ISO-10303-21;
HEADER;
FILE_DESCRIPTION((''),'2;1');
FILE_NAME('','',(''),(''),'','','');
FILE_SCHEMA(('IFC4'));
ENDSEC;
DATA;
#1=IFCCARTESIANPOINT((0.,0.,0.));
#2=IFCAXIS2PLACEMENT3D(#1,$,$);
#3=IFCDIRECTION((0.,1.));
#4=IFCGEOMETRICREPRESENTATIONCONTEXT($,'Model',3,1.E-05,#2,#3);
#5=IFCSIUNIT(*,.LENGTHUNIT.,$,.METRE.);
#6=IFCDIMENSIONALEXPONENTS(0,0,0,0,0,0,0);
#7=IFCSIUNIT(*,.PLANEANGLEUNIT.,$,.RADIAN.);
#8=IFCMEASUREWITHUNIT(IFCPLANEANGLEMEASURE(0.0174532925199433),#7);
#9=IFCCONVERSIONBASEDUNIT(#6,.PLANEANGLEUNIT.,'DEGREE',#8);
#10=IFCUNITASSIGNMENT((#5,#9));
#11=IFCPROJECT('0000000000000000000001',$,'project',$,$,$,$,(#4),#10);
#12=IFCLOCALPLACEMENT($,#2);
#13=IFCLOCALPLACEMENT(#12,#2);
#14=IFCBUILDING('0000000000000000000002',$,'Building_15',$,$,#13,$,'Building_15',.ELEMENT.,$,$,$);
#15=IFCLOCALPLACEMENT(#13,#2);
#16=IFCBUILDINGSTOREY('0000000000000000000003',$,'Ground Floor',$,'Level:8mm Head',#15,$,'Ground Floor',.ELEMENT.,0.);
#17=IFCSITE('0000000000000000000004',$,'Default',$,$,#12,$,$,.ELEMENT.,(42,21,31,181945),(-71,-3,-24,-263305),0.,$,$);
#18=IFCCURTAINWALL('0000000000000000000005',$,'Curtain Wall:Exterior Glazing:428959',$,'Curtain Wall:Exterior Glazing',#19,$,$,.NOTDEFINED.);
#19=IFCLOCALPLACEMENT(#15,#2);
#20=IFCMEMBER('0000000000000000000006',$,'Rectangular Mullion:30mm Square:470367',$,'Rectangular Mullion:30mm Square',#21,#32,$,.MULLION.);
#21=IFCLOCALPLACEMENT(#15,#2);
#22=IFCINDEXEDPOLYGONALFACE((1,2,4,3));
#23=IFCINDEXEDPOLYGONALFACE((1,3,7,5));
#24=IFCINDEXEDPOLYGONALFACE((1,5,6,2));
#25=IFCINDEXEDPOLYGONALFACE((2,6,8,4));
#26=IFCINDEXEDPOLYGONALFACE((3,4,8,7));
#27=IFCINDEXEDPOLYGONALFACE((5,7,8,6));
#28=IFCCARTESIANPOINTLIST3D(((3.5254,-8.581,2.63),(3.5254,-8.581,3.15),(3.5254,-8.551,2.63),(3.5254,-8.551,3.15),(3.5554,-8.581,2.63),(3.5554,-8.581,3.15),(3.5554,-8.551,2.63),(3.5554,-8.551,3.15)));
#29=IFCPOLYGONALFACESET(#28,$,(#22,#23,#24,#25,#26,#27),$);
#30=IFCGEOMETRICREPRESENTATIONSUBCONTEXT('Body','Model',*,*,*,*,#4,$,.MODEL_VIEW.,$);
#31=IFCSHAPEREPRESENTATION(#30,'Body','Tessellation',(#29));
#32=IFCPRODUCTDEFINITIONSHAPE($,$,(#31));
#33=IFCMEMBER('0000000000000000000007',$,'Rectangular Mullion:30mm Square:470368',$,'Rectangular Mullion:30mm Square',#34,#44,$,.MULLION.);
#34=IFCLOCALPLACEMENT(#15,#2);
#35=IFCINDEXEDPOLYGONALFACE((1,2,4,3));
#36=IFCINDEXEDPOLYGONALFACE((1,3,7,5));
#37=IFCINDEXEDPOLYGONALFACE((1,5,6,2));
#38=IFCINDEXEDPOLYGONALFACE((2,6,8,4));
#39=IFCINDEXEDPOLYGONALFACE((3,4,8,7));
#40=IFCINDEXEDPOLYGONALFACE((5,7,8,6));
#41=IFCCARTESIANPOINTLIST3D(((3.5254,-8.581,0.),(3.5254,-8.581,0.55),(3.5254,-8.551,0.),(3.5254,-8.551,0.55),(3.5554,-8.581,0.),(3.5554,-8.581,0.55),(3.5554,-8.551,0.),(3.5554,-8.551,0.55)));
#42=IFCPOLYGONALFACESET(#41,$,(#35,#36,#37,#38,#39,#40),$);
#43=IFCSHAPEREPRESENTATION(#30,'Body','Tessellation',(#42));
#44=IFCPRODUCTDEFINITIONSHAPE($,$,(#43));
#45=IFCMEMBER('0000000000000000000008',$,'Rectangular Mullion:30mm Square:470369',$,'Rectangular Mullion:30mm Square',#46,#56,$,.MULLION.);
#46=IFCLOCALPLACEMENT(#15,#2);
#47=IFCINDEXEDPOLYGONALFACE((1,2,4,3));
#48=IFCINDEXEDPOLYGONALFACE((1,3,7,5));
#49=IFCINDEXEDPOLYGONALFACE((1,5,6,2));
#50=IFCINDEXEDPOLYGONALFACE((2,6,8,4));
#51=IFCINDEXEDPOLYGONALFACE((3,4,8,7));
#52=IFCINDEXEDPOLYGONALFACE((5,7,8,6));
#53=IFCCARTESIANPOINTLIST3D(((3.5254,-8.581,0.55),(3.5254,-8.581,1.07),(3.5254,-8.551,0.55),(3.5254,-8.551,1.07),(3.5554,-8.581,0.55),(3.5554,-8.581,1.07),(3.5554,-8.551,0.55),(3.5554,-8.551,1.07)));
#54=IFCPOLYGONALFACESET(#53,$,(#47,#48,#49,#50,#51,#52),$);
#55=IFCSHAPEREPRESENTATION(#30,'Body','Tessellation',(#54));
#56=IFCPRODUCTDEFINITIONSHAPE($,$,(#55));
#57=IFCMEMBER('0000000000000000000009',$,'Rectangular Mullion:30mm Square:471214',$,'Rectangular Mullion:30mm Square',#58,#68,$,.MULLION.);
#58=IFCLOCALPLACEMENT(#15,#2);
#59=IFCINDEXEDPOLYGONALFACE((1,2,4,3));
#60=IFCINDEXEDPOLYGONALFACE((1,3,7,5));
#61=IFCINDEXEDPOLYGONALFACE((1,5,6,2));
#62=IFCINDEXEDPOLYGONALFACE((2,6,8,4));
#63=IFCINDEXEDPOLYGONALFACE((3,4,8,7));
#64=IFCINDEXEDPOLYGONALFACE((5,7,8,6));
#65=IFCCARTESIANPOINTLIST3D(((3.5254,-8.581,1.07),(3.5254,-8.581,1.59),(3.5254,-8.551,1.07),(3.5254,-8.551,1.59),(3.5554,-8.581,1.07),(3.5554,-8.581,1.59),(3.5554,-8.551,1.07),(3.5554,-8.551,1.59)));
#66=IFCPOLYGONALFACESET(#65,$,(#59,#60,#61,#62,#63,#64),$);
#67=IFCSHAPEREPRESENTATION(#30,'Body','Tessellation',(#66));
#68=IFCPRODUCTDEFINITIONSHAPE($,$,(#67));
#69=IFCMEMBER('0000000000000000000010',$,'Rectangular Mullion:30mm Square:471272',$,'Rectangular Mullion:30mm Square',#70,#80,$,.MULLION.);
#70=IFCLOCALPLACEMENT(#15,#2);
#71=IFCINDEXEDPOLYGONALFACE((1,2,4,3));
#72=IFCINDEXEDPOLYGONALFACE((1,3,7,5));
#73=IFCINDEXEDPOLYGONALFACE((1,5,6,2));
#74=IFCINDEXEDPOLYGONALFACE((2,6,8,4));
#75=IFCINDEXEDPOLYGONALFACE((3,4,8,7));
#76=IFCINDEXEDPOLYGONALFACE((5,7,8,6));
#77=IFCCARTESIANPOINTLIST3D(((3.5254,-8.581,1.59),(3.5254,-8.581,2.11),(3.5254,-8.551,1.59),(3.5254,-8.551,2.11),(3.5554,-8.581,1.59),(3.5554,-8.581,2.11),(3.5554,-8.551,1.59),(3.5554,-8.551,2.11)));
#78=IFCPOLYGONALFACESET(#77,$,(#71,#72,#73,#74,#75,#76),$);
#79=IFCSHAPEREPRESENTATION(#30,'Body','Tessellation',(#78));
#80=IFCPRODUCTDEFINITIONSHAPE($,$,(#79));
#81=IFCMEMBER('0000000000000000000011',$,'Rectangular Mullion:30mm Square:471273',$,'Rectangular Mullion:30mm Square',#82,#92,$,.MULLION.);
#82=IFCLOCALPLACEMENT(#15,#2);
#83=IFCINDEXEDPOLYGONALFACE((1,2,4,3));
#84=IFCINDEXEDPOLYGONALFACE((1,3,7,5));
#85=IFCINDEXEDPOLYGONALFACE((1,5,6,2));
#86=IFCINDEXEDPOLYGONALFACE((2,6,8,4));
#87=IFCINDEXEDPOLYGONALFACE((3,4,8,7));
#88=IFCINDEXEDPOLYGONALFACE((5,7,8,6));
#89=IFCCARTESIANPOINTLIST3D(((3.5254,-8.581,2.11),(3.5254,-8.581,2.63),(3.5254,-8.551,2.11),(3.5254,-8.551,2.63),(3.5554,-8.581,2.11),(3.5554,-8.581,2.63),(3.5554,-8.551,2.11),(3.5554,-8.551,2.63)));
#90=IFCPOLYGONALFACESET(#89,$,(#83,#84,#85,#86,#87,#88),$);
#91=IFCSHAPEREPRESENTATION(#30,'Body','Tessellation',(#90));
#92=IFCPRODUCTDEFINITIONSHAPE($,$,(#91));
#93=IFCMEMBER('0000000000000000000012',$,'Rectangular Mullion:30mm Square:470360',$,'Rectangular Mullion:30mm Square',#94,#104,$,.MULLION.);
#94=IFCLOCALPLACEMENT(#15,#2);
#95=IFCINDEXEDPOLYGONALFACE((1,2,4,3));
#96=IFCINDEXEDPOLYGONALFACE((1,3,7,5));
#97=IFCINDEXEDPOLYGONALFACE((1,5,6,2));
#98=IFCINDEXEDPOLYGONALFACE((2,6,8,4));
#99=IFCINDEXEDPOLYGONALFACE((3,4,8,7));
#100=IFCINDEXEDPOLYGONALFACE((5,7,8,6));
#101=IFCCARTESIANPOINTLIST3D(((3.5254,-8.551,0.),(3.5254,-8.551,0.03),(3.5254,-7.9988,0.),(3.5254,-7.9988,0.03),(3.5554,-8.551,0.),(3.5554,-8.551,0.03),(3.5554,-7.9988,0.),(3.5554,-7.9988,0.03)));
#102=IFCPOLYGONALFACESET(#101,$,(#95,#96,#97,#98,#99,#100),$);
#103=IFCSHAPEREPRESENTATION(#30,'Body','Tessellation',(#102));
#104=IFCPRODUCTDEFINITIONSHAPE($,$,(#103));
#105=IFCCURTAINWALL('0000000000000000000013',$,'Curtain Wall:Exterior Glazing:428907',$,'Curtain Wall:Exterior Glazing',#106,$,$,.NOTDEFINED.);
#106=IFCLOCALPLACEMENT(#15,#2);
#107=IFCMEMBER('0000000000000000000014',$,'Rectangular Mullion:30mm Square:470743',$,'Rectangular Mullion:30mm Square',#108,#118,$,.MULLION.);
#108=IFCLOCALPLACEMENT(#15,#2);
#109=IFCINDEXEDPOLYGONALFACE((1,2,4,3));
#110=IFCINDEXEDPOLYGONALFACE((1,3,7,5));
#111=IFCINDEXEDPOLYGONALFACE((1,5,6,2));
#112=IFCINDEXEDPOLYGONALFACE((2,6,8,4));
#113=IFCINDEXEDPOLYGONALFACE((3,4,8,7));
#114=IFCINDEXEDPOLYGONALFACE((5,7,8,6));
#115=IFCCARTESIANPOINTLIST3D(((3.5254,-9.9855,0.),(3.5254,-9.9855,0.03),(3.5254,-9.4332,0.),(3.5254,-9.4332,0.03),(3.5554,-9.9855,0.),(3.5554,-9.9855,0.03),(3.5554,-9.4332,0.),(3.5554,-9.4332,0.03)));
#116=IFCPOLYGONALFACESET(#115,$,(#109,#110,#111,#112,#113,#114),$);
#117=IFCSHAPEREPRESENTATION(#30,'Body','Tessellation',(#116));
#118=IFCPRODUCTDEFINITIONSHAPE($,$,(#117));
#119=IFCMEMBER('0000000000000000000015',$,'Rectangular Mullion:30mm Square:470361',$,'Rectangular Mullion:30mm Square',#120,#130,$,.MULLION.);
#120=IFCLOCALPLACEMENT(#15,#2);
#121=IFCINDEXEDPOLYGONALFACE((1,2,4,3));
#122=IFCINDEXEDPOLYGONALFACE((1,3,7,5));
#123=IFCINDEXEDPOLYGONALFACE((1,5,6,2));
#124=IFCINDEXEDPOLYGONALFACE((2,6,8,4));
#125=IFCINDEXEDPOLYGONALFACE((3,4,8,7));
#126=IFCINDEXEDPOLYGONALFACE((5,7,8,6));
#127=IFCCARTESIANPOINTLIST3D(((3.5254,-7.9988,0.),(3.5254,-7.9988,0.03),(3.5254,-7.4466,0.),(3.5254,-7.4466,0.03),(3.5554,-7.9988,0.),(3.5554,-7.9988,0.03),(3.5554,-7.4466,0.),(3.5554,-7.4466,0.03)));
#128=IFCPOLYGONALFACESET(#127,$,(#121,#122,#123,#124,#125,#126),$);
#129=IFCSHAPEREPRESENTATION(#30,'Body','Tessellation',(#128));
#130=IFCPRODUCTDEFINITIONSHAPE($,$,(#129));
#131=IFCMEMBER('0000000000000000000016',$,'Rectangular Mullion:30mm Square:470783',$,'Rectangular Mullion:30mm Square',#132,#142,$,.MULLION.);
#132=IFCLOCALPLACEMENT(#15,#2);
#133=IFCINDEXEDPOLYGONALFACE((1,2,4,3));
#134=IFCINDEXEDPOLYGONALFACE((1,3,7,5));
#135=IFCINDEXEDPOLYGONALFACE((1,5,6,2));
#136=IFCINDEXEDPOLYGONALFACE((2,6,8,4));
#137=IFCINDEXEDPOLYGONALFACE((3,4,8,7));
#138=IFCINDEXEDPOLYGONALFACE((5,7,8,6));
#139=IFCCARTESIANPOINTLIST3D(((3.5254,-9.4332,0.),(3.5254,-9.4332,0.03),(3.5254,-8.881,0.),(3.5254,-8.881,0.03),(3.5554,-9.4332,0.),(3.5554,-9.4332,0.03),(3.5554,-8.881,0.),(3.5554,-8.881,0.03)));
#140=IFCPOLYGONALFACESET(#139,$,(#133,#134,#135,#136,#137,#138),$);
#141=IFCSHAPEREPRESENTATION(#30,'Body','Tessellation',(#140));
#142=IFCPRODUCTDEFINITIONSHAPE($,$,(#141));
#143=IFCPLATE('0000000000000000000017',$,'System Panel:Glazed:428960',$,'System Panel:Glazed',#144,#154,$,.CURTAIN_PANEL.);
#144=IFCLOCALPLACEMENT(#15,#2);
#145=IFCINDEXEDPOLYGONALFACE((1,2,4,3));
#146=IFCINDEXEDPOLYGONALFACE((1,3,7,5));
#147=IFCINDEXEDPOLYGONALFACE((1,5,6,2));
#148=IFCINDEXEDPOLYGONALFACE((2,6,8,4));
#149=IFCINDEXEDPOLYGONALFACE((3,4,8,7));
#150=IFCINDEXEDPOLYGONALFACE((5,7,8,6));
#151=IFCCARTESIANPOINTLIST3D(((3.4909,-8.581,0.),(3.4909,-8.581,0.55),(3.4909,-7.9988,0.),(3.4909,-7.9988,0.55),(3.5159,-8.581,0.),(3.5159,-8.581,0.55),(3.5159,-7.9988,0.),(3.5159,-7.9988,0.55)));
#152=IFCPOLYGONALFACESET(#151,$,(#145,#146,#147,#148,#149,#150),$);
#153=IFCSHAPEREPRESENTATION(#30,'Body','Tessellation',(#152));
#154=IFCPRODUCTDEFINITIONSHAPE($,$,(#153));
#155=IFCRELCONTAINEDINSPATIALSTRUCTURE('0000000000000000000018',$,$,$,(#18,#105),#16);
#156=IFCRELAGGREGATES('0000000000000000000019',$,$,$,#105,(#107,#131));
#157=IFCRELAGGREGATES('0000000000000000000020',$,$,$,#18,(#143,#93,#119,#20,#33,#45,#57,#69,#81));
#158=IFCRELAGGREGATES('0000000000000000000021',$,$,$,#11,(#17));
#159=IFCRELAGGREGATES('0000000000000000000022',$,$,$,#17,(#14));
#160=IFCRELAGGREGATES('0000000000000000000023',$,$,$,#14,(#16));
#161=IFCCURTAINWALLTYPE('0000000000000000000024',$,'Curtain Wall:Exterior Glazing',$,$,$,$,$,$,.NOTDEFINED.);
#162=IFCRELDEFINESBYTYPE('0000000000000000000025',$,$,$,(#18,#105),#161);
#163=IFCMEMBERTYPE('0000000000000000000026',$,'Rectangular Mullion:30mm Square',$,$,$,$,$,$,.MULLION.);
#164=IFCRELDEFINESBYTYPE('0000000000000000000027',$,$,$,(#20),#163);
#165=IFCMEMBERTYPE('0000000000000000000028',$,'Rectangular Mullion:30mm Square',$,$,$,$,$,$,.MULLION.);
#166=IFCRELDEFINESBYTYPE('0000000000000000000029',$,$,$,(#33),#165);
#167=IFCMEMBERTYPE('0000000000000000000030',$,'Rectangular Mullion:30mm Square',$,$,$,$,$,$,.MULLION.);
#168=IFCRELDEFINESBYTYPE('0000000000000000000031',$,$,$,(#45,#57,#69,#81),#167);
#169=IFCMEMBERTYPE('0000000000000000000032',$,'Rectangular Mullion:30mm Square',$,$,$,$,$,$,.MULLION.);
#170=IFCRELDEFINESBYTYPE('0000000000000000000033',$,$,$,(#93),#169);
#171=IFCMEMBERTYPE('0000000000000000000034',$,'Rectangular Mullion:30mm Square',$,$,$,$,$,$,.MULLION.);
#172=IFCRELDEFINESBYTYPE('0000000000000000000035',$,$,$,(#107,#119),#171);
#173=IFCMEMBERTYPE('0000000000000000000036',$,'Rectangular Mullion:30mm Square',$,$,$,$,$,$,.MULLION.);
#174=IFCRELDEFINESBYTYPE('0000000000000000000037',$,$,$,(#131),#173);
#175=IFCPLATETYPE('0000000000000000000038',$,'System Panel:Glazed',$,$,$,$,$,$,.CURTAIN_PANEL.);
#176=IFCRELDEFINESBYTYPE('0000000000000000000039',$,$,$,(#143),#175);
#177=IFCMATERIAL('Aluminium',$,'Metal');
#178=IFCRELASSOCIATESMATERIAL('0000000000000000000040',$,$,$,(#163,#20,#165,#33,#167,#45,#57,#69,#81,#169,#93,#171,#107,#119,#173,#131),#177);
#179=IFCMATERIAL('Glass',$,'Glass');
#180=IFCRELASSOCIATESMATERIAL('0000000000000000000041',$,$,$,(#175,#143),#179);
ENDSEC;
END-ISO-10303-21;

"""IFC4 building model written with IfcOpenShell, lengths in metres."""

from ifc_helpers import new_model, entity, si_unit, converted_unit, direction, frame, origin, place, context, subcontext, project, spatial, indexed_curve, outline, extrude, source, transform, mapped, material, type_object, type_shapes, element, aggregate, save


model = new_model("IFC4")

# Units and contexts
model_context = context("Model", 3, precision=1e-05, world=origin(), true_north=direction((0.0, 1.0)))
body_context = subcontext(model_context, "Body", "Model", "MODEL_VIEW")
ifc_project = project(units=[si_unit("LENGTHUNIT", "METRE"), converted_unit("PLANEANGLEUNIT", "DEGREE", entity("IfcPlaneAngleMeasure", 0.0174532925199433), si_unit("PLANEANGLEUNIT", "RADIAN"), dimensions=[0, 0, 0, 0, 0, 0, 0])], contexts=[model_context])

# Site, building, storey
site_placement = place(None, origin())
site = spatial("IfcSite", under=ifc_project, at=site_placement, Name="Default", CompositionType="ELEMENT", RefLatitude=(42, 21, 31, 181945), RefLongitude=(-71, -3, -24, -263305), RefElevation=0.0)
building_placement = place(site_placement, origin())
building = spatial("IfcBuilding", under=site, at=building_placement, Name="Building_15", LongName="Building_15", CompositionType="ELEMENT")
storey_placement = place(building_placement, origin())
storey = spatial("IfcBuildingStorey", under=building, at=storey_placement, Name="Ground Floor", ObjectType="Level:8mm Head", LongName="Ground Floor", CompositionType="ELEMENT", Elevation=0.0)

# Curtain wall, members
curtain_wall_type = type_object("IfcCurtainWallType", Name="Curtain Wall:Exterior Glazing", PredefinedType="NOTDEFINED")
curtain_wall_1_placement = place(storey_placement, origin())
curtain_wall_1 = element("IfcCurtainWall", 1, at=curtain_wall_1_placement, inside=storey, type_object=curtain_wall_type, Name="Curtain Wall:Exterior Glazing:428959", ObjectType="Curtain Wall:Exterior Glazing", PredefinedType="NOTDEFINED")
ifc_material_1 = material(Name="Aluminium", Category="Metal")
member_type_1 = type_object("IfcMemberType", Name="Rectangular Mullion:30mm Square", PredefinedType="MULLION", material=ifc_material_1)
shared_shape_1 = source(origin(), body_context, "Body", "SweptSolid", [
    extrude(outline(indexed_curve([(-0.015, -0.015), (0.015, -0.015), (0.015, 0.015), (-0.015, 0.015), (-0.015, -0.015)], self_intersect=False)), frame((-0.015, 0.0, -0.52), z_axis=(0.0, 0.0, 1.0), x_axis=(-1.0, 0.0, 0.0)), (0.0, 0.0, 1.0), 0.52),
])
type_shapes(member_type_1, [shared_shape_1])
member_1_placement = place(curtain_wall_1_placement, frame((3.5404, -8.581, 3.15), z_axis=(0.0, 0.0, 1.0), x_axis=(0.0, -1.0, 0.0)))
member_1 = element("IfcMember", 2, at=member_1_placement, type_object=member_type_1, material=ifc_material_1, Name="Rectangular Mullion:30mm Square:470367", ObjectType="Rectangular Mullion:30mm Square", PredefinedType="MULLION", context=body_context, shape_type="MappedRepresentation", body=[
    mapped(shared_shape_1, transform((0.0, 0.0, 0.0), scale=1.0)),
])
member_type_2 = type_object("IfcMemberType", Name="Rectangular Mullion:30mm Square", PredefinedType="MULLION", material=ifc_material_1)
shared_shape_2 = source(origin(), body_context, "Body", "SweptSolid", [
    extrude(outline(indexed_curve([(-0.015, -0.015), (0.015, -0.015), (0.015, 0.015), (-0.015, 0.015), (-0.015, -0.015)], self_intersect=False)), frame((-0.015, 0.0, -0.55), z_axis=(0.0, 0.0, 1.0), x_axis=(-1.0, 0.0, 0.0)), (0.0, 0.0, 1.0), 0.55),
])
type_shapes(member_type_2, [shared_shape_2])
member_2_placement = place(curtain_wall_1_placement, frame((3.5404, -8.581, 0.55), z_axis=(0.0, 0.0, 1.0), x_axis=(0.0, -1.0, 0.0)))
member_2 = element("IfcMember", 3, at=member_2_placement, type_object=member_type_2, material=ifc_material_1, Name="Rectangular Mullion:30mm Square:470368", ObjectType="Rectangular Mullion:30mm Square", PredefinedType="MULLION", context=body_context, shape_type="MappedRepresentation", body=[
    mapped(shared_shape_2, transform((0.0, 0.0, 0.0), scale=1.0)),
])
member_type_3 = type_object("IfcMemberType", Name="Rectangular Mullion:30mm Square", PredefinedType="MULLION", material=ifc_material_1)
shared_shape_3 = source(origin(), body_context, "Body", "SweptSolid", [
    extrude(outline(indexed_curve([(-0.015, -0.015), (0.015, -0.015), (0.015, 0.015), (-0.015, 0.015), (-0.015, -0.015)], self_intersect=False)), frame((-0.015, 0.0, -0.52), z_axis=(0.0, 0.0, 1.0), x_axis=(-1.0, 0.0, 0.0)), (0.0, 0.0, 1.0), 0.52),
])
type_shapes(member_type_3, [shared_shape_3])
member_3_placement = place(curtain_wall_1_placement, frame((3.5404, -8.581, 1.07), z_axis=(0.0, 0.0, 1.0), x_axis=(0.0, -1.0, 0.0)))
member_3 = element("IfcMember", 4, at=member_3_placement, type_object=member_type_3, material=ifc_material_1, Name="Rectangular Mullion:30mm Square:470369", ObjectType="Rectangular Mullion:30mm Square", PredefinedType="MULLION", context=body_context, shape_type="MappedRepresentation", body=[
    mapped(shared_shape_3, transform((0.0, 0.0, 0.0), scale=1.0)),
])
member_4_placement = place(curtain_wall_1_placement, frame((3.5404, -8.581, 1.59), z_axis=(0.0, 0.0, 1.0), x_axis=(0.0, -1.0, 0.0)))
member_4 = element("IfcMember", 5, at=member_4_placement, type_object=member_type_3, material=ifc_material_1, Name="Rectangular Mullion:30mm Square:471214", ObjectType="Rectangular Mullion:30mm Square", PredefinedType="MULLION", context=body_context, shape_type="MappedRepresentation", body=[
    mapped(shared_shape_3, transform((0.0, 0.0, 0.0), scale=1.0)),
])
member_5_placement = place(curtain_wall_1_placement, frame((3.5404, -8.581, 2.11), z_axis=(0.0, 0.0, 1.0), x_axis=(0.0, -1.0, 0.0)))
member_5 = element("IfcMember", 6, at=member_5_placement, type_object=member_type_3, material=ifc_material_1, Name="Rectangular Mullion:30mm Square:471272", ObjectType="Rectangular Mullion:30mm Square", PredefinedType="MULLION", context=body_context, shape_type="MappedRepresentation", body=[
    mapped(shared_shape_3, transform((0.0, 0.0, 0.0), scale=1.0)),
])
member_6_placement = place(curtain_wall_1_placement, frame((3.5404, -8.581, 2.63), z_axis=(0.0, 0.0, 1.0), x_axis=(0.0, -1.0, 0.0)))
member_6 = element("IfcMember", 7, at=member_6_placement, type_object=member_type_3, material=ifc_material_1, Name="Rectangular Mullion:30mm Square:471273", ObjectType="Rectangular Mullion:30mm Square", PredefinedType="MULLION", context=body_context, shape_type="MappedRepresentation", body=[
    mapped(shared_shape_3, transform((0.0, 0.0, 0.0), scale=1.0)),
])
member_type_4 = type_object("IfcMemberType", Name="Rectangular Mullion:30mm Square", PredefinedType="MULLION", material=ifc_material_1)
shared_shape_4 = source(origin(), body_context, "Body", "SweptSolid", [
    extrude(outline(indexed_curve([(-0.015, -0.015), (0.015, -0.015), (0.015, 0.015), (-0.015, 0.015), (-0.015, -0.015)], self_intersect=False)), frame((-0.015, 0.0, -0.5522), z_axis=(0.0, 0.0, 1.0), x_axis=(-1.0, 0.0, 0.0)), (0.0, 0.0, 1.0), 0.5522),
])
type_shapes(member_type_4, [shared_shape_4])
member_7_placement = place(curtain_wall_1_placement, frame((3.5404, -8.551, 0.0), z_axis=(0.0, -1.0, 0.0), x_axis=(0.0, 0.0, -1.0)))
member_7 = element("IfcMember", 8, at=member_7_placement, type_object=member_type_4, material=ifc_material_1, Name="Rectangular Mullion:30mm Square:470360", ObjectType="Rectangular Mullion:30mm Square", PredefinedType="MULLION", context=body_context, shape_type="MappedRepresentation", body=[
    mapped(shared_shape_4, transform((0.0, 0.0, 0.0), scale=1.0)),
])

# Curtain wall, member
curtain_wall_2_placement = place(storey_placement, origin())
curtain_wall_2 = element("IfcCurtainWall", 9, at=curtain_wall_2_placement, inside=storey, type_object=curtain_wall_type, Name="Curtain Wall:Exterior Glazing:428907", ObjectType="Curtain Wall:Exterior Glazing", PredefinedType="NOTDEFINED")
member_type_5 = type_object("IfcMemberType", Name="Rectangular Mullion:30mm Square", PredefinedType="MULLION", material=ifc_material_1)
shared_shape_5 = source(origin(), body_context, "Body", "SweptSolid", [
    extrude(outline(indexed_curve([(-0.015, -0.015), (0.015, -0.015), (0.015, 0.015), (-0.015, 0.015), (-0.015, -0.015)], self_intersect=False)), frame((-0.015, 0.0, -0.5522), z_axis=(0.0, 0.0, 1.0), x_axis=(-1.0, 0.0, 0.0)), (0.0, 0.0, 1.0), 0.5522),
])
type_shapes(member_type_5, [shared_shape_5])
member_8_placement = place(curtain_wall_2_placement, frame((3.5404, -9.9855, 0.0), z_axis=(0.0, -1.0, 0.0), x_axis=(0.0, 0.0, -1.0)))
member_8 = element("IfcMember", 10, at=member_8_placement, type_object=member_type_5, material=ifc_material_1, Name="Rectangular Mullion:30mm Square:470743", ObjectType="Rectangular Mullion:30mm Square", PredefinedType="MULLION", context=body_context, shape_type="MappedRepresentation", body=[
    mapped(shared_shape_5, transform((0.0, 0.0, 0.0), scale=1.0)),
])

# Members
member_9_placement = place(curtain_wall_1_placement, frame((3.5404, -7.9988, 0.0), z_axis=(0.0, -1.0, 0.0), x_axis=(0.0, 0.0, -1.0)))
member_9 = element("IfcMember", 11, at=member_9_placement, type_object=member_type_5, material=ifc_material_1, Name="Rectangular Mullion:30mm Square:470361", ObjectType="Rectangular Mullion:30mm Square", PredefinedType="MULLION", context=body_context, shape_type="MappedRepresentation", body=[
    mapped(shared_shape_5, transform((0.0, 0.0, 0.0), scale=1.0)),
])
member_type_6 = type_object("IfcMemberType", Name="Rectangular Mullion:30mm Square", PredefinedType="MULLION", material=ifc_material_1)
shared_shape_6 = source(origin(), body_context, "Body", "SweptSolid", [
    extrude(outline(indexed_curve([(-0.015, -0.015), (0.015, -0.015), (0.015, 0.015), (-0.015, 0.015), (-0.015, -0.015)], self_intersect=False)), frame((-0.015, 0.0, -0.5522), z_axis=(0.0, 0.0, 1.0), x_axis=(-1.0, 0.0, 0.0)), (0.0, 0.0, 1.0), 0.5522),
])
type_shapes(member_type_6, [shared_shape_6])
member_10_placement = place(curtain_wall_2_placement, frame((3.5404, -9.4332, 0.0), z_axis=(0.0, -1.0, 0.0), x_axis=(0.0, 0.0, -1.0)))
member_10 = element("IfcMember", 12, at=member_10_placement, type_object=member_type_6, material=ifc_material_1, Name="Rectangular Mullion:30mm Square:470783", ObjectType="Rectangular Mullion:30mm Square", PredefinedType="MULLION", context=body_context, shape_type="MappedRepresentation", body=[
    mapped(shared_shape_6, transform((0.0, 0.0, 0.0), scale=1.0)),
])

# Plate
ifc_material_2 = material(Name="Glass", Category="Glass")
plate_type_1 = type_object("IfcPlateType", Name="System Panel:Glazed", PredefinedType="CURTAIN_PANEL", material=ifc_material_2)
shared_shape_7 = source(origin(), body_context, "Body", "SweptSolid", [
    extrude(outline(indexed_curve([(-0.0125, -0.2911), (0.0125, -0.2911), (0.0125, 0.2911), (-0.0125, 0.2911), (-0.0125, -0.2911)], self_intersect=False)), frame((0.0, 0.037, 0.0), z_axis=(0.0, 0.0, 1.0), x_axis=(0.0, 1.0, 0.0)), (0.0, 0.0, 1.0), 0.55),
])
type_shapes(plate_type_1, [shared_shape_7])
plate_1_placement = place(curtain_wall_1_placement, frame((3.5404, -8.2899, 0.0), z_axis=(0.0, 0.0, 1.0), x_axis=(0.0, 1.0, 0.0)))
plate_1 = element("IfcPlate", 13, at=plate_1_placement, type_object=plate_type_1, material=ifc_material_2, Name="System Panel:Glazed:428960", ObjectType="System Panel:Glazed", PredefinedType="CURTAIN_PANEL", context=body_context, shape_type="MappedRepresentation", body=[
    mapped(shared_shape_7, transform((0.0, 0.0, 0.0), scale=1.0)),
])
aggregate(curtain_wall_2, [member_8, member_10])
aggregate(curtain_wall_1, [plate_1, member_7, member_9, member_1, member_2, member_3, member_4, member_5, member_6])

save(model, "model.ifc")
